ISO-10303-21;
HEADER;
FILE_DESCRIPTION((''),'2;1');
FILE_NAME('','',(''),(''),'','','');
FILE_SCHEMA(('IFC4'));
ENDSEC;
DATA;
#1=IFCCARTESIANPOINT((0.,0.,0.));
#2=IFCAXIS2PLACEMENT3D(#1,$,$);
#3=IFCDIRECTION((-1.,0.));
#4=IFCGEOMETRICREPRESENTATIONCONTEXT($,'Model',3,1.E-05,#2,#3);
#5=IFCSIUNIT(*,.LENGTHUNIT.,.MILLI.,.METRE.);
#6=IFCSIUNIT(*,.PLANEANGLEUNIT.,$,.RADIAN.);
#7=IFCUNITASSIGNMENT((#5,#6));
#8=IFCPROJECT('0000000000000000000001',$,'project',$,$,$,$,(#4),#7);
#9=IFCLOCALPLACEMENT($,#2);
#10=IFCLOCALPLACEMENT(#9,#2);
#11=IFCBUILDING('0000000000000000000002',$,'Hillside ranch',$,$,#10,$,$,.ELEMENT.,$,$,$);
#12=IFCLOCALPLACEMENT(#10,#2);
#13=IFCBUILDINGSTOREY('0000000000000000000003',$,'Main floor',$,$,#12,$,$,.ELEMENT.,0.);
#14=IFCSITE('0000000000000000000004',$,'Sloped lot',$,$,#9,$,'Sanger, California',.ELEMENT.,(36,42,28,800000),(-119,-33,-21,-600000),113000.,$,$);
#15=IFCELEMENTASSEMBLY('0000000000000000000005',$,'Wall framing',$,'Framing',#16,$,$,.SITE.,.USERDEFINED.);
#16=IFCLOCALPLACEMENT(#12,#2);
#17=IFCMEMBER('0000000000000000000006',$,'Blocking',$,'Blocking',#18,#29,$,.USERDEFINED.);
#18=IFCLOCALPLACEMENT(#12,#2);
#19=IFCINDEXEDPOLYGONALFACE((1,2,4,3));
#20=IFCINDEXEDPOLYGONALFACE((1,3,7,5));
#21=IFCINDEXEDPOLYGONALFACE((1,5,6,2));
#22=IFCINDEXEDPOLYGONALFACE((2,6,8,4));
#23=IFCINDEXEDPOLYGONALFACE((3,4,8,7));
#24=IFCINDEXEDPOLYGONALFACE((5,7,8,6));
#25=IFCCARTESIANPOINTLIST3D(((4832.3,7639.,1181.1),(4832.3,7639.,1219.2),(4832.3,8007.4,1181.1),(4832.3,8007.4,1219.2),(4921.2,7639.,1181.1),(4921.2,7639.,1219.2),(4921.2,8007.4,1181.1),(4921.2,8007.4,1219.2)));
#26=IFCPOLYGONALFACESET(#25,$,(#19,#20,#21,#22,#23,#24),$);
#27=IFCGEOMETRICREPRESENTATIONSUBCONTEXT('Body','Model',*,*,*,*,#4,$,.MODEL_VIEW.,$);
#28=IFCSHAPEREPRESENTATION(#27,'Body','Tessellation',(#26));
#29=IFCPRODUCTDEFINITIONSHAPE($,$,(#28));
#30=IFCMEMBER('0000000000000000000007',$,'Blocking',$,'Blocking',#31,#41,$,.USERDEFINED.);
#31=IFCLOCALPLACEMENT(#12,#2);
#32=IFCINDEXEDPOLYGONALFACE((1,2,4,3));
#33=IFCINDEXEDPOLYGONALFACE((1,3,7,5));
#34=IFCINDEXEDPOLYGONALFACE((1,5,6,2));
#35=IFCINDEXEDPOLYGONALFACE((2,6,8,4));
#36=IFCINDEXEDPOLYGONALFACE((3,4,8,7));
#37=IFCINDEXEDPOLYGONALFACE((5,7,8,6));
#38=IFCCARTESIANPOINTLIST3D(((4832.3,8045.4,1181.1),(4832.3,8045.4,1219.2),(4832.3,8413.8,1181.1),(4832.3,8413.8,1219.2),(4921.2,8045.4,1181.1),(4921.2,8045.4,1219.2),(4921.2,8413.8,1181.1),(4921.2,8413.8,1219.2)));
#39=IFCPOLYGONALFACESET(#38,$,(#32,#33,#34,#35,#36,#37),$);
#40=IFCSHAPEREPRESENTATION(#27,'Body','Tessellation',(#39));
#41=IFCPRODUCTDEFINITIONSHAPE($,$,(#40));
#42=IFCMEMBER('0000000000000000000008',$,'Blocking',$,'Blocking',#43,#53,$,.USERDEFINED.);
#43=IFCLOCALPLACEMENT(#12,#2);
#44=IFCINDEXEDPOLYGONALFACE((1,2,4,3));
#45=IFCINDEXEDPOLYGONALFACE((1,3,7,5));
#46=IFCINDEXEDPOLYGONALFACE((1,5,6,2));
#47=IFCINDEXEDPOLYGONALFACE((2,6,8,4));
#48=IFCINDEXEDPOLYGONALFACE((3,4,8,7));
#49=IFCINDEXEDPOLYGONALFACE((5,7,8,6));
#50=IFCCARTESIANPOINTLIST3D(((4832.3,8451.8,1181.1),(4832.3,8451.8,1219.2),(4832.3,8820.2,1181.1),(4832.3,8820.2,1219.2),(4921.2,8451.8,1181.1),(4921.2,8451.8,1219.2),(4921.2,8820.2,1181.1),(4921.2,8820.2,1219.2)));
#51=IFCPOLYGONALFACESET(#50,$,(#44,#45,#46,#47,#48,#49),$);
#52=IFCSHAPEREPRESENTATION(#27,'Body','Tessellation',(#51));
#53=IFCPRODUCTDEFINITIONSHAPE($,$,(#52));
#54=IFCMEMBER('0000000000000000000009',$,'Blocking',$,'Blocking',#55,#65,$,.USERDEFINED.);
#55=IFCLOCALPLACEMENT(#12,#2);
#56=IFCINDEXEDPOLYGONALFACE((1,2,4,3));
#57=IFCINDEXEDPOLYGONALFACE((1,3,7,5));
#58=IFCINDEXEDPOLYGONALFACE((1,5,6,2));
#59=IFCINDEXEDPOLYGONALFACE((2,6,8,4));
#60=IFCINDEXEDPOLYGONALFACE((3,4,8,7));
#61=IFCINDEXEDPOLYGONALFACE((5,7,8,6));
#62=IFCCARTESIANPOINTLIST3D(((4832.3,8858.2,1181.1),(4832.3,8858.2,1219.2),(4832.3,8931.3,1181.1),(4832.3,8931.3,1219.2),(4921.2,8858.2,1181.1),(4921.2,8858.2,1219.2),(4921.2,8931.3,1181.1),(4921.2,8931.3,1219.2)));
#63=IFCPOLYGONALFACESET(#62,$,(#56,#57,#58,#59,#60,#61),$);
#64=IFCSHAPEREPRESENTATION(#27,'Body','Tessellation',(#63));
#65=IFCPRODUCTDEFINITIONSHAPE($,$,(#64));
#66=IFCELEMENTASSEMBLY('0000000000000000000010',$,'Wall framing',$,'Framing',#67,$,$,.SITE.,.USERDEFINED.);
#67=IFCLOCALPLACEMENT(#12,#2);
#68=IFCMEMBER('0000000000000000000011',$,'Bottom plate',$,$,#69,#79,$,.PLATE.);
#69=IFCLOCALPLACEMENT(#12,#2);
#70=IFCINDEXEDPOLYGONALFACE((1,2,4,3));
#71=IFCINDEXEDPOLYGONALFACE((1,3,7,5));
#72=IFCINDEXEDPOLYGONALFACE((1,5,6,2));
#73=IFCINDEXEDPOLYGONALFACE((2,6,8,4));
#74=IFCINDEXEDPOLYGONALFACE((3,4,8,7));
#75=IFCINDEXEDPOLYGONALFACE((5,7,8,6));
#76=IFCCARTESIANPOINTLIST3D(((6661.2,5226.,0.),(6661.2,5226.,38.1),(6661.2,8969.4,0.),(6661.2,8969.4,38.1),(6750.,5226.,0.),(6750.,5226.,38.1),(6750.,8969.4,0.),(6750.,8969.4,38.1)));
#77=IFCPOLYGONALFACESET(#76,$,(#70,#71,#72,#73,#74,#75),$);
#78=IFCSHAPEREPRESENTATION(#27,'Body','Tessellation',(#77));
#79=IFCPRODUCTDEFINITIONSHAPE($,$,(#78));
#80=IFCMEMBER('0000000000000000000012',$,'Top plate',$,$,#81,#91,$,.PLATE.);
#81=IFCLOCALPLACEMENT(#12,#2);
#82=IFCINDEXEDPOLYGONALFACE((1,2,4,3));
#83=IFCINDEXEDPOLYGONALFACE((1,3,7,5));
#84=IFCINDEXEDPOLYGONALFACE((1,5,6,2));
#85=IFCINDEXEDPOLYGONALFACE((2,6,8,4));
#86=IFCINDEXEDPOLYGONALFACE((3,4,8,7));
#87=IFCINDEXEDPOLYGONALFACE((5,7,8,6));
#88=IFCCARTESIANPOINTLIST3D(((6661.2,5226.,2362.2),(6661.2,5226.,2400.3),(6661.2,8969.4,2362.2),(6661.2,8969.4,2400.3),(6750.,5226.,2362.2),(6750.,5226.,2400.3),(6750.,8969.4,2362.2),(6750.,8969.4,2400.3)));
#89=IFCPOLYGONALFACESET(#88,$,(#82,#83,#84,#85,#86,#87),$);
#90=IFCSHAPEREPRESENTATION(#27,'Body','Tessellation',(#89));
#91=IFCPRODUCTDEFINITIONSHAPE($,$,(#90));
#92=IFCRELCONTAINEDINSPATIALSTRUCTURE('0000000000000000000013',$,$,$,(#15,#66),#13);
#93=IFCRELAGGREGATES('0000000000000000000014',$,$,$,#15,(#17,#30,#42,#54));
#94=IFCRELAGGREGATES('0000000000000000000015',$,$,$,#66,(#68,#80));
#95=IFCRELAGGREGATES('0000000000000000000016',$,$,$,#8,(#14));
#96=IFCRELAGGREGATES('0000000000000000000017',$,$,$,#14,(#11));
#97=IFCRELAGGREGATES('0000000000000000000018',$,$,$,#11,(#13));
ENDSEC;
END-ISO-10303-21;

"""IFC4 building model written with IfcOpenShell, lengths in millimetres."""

from ifc_helpers import new_model, si_unit, direction, frame, origin, origin_with_axes, place, context, subcontext, project, spatial, polyline, outline, extrude, element, aggregate, save


model = new_model("IFC4")

# Units and contexts
model_context = context("Model", 3, precision=1e-05, world=origin(), true_north=direction((-1.0, 0.0)))
body_context = subcontext(model_context, "Body", "Model", "MODEL_VIEW")
ifc_project = project(units=[si_unit("LENGTHUNIT", "METRE", prefix="MILLI"), si_unit("PLANEANGLEUNIT", "RADIAN")], contexts=[model_context])

# Site, building, storey
site_placement = place(None, origin())
site = spatial("IfcSite", under=ifc_project, at=site_placement, Name="Sloped lot", LongName="Sanger, California", CompositionType="ELEMENT", RefLatitude=(36, 42, 28, 800000), RefLongitude=(-119, -33, -21, -600000), RefElevation=113000.0)
building_placement = place(site_placement, origin())
building = spatial("IfcBuilding", under=site, at=building_placement, Name="Hillside ranch", CompositionType="ELEMENT")
storey_placement = place(building_placement, origin())
storey = spatial("IfcBuildingStorey", under=building, at=storey_placement, Name="Main floor", CompositionType="ELEMENT", Elevation=0.0)

# Element assemblies, members
assembly_1_placement = place(storey_placement, origin_with_axes())
assembly_1 = element("IfcElementAssembly", 1, at=assembly_1_placement, inside=storey, Name="Wall framing", ObjectType="Framing", AssemblyPlace="SITE", PredefinedType="USERDEFINED")
member_1_placement = place(storey_placement, origin_with_axes())
member_1 = element("IfcMember", 2, at=member_1_placement, Name="Blocking", ObjectType="Blocking", PredefinedType="USERDEFINED", context=body_context, shape_type="SweptSolid", body=[
    extrude(outline(polyline([(0.0, 0.0), (368.3, 0.0), (368.3, 88.9), (0.0, 88.9), (0.0, 0.0)])), frame((4921.2, 7639.1, 1181.1), z_axis=(0.0, 0.0, 1.0), x_axis=(0.0, 1.0, 0.0)), (0.0, 0.0, 1.0), 38.1),
])
member_2_placement = place(storey_placement, origin_with_axes())
member_2 = element("IfcMember", 3, at=member_2_placement, Name="Blocking", ObjectType="Blocking", PredefinedType="USERDEFINED", context=body_context, shape_type="SweptSolid", body=[
    extrude(outline(polyline([(0.0, 0.0), (368.3, 0.0), (368.3, 88.9), (0.0, 88.9), (0.0, 0.0)])), frame((4921.2, 8045.4, 1181.1), z_axis=(0.0, 0.0, 1.0), x_axis=(0.0, 1.0, 0.0)), (0.0, 0.0, 1.0), 38.1),
])
member_3_placement = place(storey_placement, origin_with_axes())
member_3 = element("IfcMember", 4, at=member_3_placement, Name="Blocking", ObjectType="Blocking", PredefinedType="USERDEFINED", context=body_context, shape_type="SweptSolid", body=[
    extrude(outline(polyline([(0.0, 0.0), (368.3, 0.0), (368.3, 88.9), (0.0, 88.9), (0.0, 0.0)])), frame((4921.2, 8451.9, 1181.1), z_axis=(0.0, 0.0, 1.0), x_axis=(0.0, 1.0, 0.0)), (0.0, 0.0, 1.0), 38.1),
])
member_4_placement = place(storey_placement, origin_with_axes())
member_4 = element("IfcMember", 5, at=member_4_placement, Name="Blocking", ObjectType="Blocking", PredefinedType="USERDEFINED", context=body_context, shape_type="SweptSolid", body=[
    extrude(outline(polyline([(0.0, 0.0), (73.0, 0.0), (73.0, 88.9), (0.0, 88.9), (0.0, 0.0)])), frame((4921.2, 8858.2, 1181.1), z_axis=(0.0, 0.0, 1.0), x_axis=(0.0, 1.0, 0.0)), (0.0, 0.0, 1.0), 38.1),
])
aggregate(assembly_1, [member_1, member_2, member_3, member_4])
assembly_2_placement = place(storey_placement, origin_with_axes())
assembly_2 = element("IfcElementAssembly", 6, at=assembly_2_placement, inside=storey, Name="Wall framing", ObjectType="Framing", AssemblyPlace="SITE", PredefinedType="USERDEFINED")
member_5_placement = place(storey_placement, origin_with_axes())
member_5 = element("IfcMember", 7, at=member_5_placement, Name="Bottom plate", PredefinedType="PLATE", context=body_context, shape_type="SweptSolid", body=[
    extrude(outline(polyline([(0.0, 0.0), (3743.3, 0.0), (3743.3, 88.9), (0.0, 88.9), (0.0, 0.0)])), frame((6750.1, 5226.1, 0.0), z_axis=(0.0, 0.0, 1.0), x_axis=(0.0, 1.0, 0.0)), (0.0, 0.0, 1.0), 38.1),
])
member_6_placement = place(storey_placement, origin_with_axes())
member_6 = element("IfcMember", 8, at=member_6_placement, Name="Top plate", PredefinedType="PLATE", context=body_context, shape_type="SweptSolid", body=[
    extrude(outline(polyline([(0.0, 0.0), (3743.3, 0.0), (3743.3, 88.9), (0.0, 88.9), (0.0, 0.0)])), frame((6750.1, 5226.1, 2362.2), z_axis=(0.0, 0.0, 1.0), x_axis=(0.0, 1.0, 0.0)), (0.0, 0.0, 1.0), 38.1),
])
aggregate(assembly_2, [member_5, member_6])

save(model, "model.ifc")
